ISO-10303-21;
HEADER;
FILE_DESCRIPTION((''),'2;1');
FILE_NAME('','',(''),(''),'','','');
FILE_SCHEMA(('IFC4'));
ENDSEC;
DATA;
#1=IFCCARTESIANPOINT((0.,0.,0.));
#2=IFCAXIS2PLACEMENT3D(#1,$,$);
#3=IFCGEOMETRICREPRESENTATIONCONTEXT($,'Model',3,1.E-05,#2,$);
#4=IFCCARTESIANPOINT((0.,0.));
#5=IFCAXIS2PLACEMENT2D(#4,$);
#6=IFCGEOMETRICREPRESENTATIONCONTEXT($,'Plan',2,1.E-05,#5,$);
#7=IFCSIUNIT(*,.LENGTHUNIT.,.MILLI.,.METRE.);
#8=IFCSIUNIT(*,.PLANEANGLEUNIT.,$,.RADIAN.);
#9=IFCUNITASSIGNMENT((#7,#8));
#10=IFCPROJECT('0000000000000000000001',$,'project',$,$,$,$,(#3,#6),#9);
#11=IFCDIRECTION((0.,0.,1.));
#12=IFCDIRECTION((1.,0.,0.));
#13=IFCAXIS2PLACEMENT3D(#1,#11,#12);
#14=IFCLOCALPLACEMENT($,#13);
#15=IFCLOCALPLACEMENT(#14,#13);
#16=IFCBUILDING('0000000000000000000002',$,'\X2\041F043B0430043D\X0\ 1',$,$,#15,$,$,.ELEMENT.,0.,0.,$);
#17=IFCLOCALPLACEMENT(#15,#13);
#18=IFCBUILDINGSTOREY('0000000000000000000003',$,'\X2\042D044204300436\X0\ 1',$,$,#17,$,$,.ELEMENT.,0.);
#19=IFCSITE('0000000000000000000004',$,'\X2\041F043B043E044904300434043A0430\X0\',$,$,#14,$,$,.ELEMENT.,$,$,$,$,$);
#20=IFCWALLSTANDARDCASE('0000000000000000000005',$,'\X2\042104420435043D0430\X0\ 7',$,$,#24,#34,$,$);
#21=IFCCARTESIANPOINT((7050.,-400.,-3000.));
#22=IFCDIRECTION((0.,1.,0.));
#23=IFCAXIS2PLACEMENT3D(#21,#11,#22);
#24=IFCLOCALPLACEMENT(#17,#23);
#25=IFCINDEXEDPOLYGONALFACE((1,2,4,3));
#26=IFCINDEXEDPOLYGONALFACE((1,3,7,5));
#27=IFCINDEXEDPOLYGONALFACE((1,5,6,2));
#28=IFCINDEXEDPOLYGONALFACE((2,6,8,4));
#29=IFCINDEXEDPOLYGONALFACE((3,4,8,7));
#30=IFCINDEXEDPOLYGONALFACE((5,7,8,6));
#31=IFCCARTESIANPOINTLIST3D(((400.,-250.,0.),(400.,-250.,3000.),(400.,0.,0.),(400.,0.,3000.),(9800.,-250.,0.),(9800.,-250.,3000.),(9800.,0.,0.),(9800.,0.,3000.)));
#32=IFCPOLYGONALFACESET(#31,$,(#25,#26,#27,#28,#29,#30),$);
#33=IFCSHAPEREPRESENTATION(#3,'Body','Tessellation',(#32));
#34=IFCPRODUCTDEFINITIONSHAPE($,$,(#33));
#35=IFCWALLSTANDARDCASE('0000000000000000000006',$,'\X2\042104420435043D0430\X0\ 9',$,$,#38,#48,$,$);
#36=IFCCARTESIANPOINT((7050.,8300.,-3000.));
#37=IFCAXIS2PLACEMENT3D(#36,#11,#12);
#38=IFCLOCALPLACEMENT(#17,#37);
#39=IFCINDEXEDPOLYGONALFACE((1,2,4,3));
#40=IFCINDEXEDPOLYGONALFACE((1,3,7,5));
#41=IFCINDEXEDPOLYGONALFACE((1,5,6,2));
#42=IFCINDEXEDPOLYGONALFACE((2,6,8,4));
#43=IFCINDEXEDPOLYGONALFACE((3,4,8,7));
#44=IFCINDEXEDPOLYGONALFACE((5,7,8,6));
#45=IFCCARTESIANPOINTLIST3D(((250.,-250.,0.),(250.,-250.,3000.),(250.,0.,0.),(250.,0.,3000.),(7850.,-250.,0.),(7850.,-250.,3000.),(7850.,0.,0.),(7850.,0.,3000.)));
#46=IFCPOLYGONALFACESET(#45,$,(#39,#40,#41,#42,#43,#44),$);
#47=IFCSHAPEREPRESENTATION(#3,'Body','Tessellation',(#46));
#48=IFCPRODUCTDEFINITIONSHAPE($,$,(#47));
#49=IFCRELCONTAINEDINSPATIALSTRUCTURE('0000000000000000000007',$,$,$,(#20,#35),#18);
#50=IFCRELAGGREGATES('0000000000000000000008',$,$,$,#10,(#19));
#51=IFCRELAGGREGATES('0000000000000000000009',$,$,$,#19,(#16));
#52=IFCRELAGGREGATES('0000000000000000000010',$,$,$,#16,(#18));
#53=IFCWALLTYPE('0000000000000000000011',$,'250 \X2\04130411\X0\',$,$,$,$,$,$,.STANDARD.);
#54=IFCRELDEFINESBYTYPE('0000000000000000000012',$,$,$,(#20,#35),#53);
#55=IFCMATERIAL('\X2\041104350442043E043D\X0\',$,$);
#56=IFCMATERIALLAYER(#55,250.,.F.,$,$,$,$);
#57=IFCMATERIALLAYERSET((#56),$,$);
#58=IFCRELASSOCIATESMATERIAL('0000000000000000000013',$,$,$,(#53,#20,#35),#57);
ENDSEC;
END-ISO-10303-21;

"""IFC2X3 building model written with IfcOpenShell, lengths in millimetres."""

from ifc_helpers import new_model, si_unit, frame, origin, origin_with_axes, origin_2d, place, context, project, spatial, polyline, segment, composite_curve, outline, extrude, material, layer, layer_set, layer_usage, type_object, element, save


model = new_model("IFC2X3")

# Units and contexts
model_context = context("Model", 3, precision=1e-05, world=origin())
plan_context = context("Plan", 2, precision=1e-05, world=origin_2d())
ifc_project = project(units=[si_unit("LENGTHUNIT", "METRE", prefix="MILLI"), si_unit("PLANEANGLEUNIT", "RADIAN")], contexts=[model_context, plan_context])

# Site, building, storey
site_placement = place(None, origin_with_axes())
site = spatial("IfcSite", under=ifc_project, at=site_placement, Name="Площадка", CompositionType="ELEMENT")
building_placement = place(site_placement, origin_with_axes())
building = spatial("IfcBuilding", under=site, at=building_placement, Name="План 1", CompositionType="ELEMENT", ElevationOfRefHeight=0.0, ElevationOfTerrain=0.0)
storey_placement = place(building_placement, origin_with_axes())
storey = spatial("IfcBuildingStorey", under=building, at=storey_placement, Name="Этаж 1", CompositionType="ELEMENT", Elevation=0.0)

# Walls
ifc_material = material(Name="Бетон")
ifc_layer_1 = layer(ifc_material, 250.0, ventilated=False)
ifc_layer_set_1 = layer_set([ifc_layer_1])
ifc_layer_usage_1 = layer_usage(ifc_layer_set_1, "AXIS2", "POSITIVE", -250.0)
wall_type_1 = type_object("IfcWallType", Name="250 ГБ", PredefinedType="STANDARD", material=ifc_layer_set_1)
wall_1_placement = place(storey_placement, frame((7050.0, -400.0, -3000.0), z_axis=(0.0, 0.0, 1.0), x_axis=(0.0, 1.0, 0.0)))
element("IfcWallStandardCase", 1, at=wall_1_placement, inside=storey, type_object=wall_type_1, material=ifc_layer_usage_1, Name="Стена 7", context=model_context, shape_type="SweptSolid", body=[
    extrude(outline(composite_curve([segment(polyline([(400.0, 0.0), (400.0, -250.0)]), True, "CONTINUOUS"), segment(polyline([(400.0, -250.0), (9800.0, -250.0)]), True, "CONTINUOUS"), segment(polyline([(9800.0, -250.0), (9800.0, 0.0)]), True, "CONTINUOUS"), segment(polyline([(9800.0, 0.0), (400.0, 0.0)]), True, "CONTINUOUS")], self_intersect=False)), origin_with_axes(), (0.0, 0.0, 1.0), 3000.0),
])
ifc_layer_usage_2 = layer_usage(ifc_layer_set_1, "AXIS2", "POSITIVE", -250.0)
wall_2_placement = place(storey_placement, frame((7050.0, 8300.0, -3000.0), z_axis=(0.0, 0.0, 1.0), x_axis=(1.0, 0.0, 0.0)))
element("IfcWallStandardCase", 2, at=wall_2_placement, inside=storey, type_object=wall_type_1, material=ifc_layer_usage_2, Name="Стена 9", context=model_context, shape_type="SweptSolid", body=[
    extrude(outline(composite_curve([segment(polyline([(250.0, 0.0), (250.0, -250.0)]), True, "CONTINUOUS"), segment(polyline([(250.0, -250.0), (7850.0, -250.0)]), True, "CONTINUOUS"), segment(polyline([(7850.0, -250.0), (7850.0, 0.0)]), True, "CONTINUOUS"), segment(polyline([(7850.0, 0.0), (250.0, 0.0)]), True, "CONTINUOUS")], self_intersect=False)), origin_with_axes(), (0.0, 0.0, 1.0), 3000.0),
])

save(model, "model.ifc")
